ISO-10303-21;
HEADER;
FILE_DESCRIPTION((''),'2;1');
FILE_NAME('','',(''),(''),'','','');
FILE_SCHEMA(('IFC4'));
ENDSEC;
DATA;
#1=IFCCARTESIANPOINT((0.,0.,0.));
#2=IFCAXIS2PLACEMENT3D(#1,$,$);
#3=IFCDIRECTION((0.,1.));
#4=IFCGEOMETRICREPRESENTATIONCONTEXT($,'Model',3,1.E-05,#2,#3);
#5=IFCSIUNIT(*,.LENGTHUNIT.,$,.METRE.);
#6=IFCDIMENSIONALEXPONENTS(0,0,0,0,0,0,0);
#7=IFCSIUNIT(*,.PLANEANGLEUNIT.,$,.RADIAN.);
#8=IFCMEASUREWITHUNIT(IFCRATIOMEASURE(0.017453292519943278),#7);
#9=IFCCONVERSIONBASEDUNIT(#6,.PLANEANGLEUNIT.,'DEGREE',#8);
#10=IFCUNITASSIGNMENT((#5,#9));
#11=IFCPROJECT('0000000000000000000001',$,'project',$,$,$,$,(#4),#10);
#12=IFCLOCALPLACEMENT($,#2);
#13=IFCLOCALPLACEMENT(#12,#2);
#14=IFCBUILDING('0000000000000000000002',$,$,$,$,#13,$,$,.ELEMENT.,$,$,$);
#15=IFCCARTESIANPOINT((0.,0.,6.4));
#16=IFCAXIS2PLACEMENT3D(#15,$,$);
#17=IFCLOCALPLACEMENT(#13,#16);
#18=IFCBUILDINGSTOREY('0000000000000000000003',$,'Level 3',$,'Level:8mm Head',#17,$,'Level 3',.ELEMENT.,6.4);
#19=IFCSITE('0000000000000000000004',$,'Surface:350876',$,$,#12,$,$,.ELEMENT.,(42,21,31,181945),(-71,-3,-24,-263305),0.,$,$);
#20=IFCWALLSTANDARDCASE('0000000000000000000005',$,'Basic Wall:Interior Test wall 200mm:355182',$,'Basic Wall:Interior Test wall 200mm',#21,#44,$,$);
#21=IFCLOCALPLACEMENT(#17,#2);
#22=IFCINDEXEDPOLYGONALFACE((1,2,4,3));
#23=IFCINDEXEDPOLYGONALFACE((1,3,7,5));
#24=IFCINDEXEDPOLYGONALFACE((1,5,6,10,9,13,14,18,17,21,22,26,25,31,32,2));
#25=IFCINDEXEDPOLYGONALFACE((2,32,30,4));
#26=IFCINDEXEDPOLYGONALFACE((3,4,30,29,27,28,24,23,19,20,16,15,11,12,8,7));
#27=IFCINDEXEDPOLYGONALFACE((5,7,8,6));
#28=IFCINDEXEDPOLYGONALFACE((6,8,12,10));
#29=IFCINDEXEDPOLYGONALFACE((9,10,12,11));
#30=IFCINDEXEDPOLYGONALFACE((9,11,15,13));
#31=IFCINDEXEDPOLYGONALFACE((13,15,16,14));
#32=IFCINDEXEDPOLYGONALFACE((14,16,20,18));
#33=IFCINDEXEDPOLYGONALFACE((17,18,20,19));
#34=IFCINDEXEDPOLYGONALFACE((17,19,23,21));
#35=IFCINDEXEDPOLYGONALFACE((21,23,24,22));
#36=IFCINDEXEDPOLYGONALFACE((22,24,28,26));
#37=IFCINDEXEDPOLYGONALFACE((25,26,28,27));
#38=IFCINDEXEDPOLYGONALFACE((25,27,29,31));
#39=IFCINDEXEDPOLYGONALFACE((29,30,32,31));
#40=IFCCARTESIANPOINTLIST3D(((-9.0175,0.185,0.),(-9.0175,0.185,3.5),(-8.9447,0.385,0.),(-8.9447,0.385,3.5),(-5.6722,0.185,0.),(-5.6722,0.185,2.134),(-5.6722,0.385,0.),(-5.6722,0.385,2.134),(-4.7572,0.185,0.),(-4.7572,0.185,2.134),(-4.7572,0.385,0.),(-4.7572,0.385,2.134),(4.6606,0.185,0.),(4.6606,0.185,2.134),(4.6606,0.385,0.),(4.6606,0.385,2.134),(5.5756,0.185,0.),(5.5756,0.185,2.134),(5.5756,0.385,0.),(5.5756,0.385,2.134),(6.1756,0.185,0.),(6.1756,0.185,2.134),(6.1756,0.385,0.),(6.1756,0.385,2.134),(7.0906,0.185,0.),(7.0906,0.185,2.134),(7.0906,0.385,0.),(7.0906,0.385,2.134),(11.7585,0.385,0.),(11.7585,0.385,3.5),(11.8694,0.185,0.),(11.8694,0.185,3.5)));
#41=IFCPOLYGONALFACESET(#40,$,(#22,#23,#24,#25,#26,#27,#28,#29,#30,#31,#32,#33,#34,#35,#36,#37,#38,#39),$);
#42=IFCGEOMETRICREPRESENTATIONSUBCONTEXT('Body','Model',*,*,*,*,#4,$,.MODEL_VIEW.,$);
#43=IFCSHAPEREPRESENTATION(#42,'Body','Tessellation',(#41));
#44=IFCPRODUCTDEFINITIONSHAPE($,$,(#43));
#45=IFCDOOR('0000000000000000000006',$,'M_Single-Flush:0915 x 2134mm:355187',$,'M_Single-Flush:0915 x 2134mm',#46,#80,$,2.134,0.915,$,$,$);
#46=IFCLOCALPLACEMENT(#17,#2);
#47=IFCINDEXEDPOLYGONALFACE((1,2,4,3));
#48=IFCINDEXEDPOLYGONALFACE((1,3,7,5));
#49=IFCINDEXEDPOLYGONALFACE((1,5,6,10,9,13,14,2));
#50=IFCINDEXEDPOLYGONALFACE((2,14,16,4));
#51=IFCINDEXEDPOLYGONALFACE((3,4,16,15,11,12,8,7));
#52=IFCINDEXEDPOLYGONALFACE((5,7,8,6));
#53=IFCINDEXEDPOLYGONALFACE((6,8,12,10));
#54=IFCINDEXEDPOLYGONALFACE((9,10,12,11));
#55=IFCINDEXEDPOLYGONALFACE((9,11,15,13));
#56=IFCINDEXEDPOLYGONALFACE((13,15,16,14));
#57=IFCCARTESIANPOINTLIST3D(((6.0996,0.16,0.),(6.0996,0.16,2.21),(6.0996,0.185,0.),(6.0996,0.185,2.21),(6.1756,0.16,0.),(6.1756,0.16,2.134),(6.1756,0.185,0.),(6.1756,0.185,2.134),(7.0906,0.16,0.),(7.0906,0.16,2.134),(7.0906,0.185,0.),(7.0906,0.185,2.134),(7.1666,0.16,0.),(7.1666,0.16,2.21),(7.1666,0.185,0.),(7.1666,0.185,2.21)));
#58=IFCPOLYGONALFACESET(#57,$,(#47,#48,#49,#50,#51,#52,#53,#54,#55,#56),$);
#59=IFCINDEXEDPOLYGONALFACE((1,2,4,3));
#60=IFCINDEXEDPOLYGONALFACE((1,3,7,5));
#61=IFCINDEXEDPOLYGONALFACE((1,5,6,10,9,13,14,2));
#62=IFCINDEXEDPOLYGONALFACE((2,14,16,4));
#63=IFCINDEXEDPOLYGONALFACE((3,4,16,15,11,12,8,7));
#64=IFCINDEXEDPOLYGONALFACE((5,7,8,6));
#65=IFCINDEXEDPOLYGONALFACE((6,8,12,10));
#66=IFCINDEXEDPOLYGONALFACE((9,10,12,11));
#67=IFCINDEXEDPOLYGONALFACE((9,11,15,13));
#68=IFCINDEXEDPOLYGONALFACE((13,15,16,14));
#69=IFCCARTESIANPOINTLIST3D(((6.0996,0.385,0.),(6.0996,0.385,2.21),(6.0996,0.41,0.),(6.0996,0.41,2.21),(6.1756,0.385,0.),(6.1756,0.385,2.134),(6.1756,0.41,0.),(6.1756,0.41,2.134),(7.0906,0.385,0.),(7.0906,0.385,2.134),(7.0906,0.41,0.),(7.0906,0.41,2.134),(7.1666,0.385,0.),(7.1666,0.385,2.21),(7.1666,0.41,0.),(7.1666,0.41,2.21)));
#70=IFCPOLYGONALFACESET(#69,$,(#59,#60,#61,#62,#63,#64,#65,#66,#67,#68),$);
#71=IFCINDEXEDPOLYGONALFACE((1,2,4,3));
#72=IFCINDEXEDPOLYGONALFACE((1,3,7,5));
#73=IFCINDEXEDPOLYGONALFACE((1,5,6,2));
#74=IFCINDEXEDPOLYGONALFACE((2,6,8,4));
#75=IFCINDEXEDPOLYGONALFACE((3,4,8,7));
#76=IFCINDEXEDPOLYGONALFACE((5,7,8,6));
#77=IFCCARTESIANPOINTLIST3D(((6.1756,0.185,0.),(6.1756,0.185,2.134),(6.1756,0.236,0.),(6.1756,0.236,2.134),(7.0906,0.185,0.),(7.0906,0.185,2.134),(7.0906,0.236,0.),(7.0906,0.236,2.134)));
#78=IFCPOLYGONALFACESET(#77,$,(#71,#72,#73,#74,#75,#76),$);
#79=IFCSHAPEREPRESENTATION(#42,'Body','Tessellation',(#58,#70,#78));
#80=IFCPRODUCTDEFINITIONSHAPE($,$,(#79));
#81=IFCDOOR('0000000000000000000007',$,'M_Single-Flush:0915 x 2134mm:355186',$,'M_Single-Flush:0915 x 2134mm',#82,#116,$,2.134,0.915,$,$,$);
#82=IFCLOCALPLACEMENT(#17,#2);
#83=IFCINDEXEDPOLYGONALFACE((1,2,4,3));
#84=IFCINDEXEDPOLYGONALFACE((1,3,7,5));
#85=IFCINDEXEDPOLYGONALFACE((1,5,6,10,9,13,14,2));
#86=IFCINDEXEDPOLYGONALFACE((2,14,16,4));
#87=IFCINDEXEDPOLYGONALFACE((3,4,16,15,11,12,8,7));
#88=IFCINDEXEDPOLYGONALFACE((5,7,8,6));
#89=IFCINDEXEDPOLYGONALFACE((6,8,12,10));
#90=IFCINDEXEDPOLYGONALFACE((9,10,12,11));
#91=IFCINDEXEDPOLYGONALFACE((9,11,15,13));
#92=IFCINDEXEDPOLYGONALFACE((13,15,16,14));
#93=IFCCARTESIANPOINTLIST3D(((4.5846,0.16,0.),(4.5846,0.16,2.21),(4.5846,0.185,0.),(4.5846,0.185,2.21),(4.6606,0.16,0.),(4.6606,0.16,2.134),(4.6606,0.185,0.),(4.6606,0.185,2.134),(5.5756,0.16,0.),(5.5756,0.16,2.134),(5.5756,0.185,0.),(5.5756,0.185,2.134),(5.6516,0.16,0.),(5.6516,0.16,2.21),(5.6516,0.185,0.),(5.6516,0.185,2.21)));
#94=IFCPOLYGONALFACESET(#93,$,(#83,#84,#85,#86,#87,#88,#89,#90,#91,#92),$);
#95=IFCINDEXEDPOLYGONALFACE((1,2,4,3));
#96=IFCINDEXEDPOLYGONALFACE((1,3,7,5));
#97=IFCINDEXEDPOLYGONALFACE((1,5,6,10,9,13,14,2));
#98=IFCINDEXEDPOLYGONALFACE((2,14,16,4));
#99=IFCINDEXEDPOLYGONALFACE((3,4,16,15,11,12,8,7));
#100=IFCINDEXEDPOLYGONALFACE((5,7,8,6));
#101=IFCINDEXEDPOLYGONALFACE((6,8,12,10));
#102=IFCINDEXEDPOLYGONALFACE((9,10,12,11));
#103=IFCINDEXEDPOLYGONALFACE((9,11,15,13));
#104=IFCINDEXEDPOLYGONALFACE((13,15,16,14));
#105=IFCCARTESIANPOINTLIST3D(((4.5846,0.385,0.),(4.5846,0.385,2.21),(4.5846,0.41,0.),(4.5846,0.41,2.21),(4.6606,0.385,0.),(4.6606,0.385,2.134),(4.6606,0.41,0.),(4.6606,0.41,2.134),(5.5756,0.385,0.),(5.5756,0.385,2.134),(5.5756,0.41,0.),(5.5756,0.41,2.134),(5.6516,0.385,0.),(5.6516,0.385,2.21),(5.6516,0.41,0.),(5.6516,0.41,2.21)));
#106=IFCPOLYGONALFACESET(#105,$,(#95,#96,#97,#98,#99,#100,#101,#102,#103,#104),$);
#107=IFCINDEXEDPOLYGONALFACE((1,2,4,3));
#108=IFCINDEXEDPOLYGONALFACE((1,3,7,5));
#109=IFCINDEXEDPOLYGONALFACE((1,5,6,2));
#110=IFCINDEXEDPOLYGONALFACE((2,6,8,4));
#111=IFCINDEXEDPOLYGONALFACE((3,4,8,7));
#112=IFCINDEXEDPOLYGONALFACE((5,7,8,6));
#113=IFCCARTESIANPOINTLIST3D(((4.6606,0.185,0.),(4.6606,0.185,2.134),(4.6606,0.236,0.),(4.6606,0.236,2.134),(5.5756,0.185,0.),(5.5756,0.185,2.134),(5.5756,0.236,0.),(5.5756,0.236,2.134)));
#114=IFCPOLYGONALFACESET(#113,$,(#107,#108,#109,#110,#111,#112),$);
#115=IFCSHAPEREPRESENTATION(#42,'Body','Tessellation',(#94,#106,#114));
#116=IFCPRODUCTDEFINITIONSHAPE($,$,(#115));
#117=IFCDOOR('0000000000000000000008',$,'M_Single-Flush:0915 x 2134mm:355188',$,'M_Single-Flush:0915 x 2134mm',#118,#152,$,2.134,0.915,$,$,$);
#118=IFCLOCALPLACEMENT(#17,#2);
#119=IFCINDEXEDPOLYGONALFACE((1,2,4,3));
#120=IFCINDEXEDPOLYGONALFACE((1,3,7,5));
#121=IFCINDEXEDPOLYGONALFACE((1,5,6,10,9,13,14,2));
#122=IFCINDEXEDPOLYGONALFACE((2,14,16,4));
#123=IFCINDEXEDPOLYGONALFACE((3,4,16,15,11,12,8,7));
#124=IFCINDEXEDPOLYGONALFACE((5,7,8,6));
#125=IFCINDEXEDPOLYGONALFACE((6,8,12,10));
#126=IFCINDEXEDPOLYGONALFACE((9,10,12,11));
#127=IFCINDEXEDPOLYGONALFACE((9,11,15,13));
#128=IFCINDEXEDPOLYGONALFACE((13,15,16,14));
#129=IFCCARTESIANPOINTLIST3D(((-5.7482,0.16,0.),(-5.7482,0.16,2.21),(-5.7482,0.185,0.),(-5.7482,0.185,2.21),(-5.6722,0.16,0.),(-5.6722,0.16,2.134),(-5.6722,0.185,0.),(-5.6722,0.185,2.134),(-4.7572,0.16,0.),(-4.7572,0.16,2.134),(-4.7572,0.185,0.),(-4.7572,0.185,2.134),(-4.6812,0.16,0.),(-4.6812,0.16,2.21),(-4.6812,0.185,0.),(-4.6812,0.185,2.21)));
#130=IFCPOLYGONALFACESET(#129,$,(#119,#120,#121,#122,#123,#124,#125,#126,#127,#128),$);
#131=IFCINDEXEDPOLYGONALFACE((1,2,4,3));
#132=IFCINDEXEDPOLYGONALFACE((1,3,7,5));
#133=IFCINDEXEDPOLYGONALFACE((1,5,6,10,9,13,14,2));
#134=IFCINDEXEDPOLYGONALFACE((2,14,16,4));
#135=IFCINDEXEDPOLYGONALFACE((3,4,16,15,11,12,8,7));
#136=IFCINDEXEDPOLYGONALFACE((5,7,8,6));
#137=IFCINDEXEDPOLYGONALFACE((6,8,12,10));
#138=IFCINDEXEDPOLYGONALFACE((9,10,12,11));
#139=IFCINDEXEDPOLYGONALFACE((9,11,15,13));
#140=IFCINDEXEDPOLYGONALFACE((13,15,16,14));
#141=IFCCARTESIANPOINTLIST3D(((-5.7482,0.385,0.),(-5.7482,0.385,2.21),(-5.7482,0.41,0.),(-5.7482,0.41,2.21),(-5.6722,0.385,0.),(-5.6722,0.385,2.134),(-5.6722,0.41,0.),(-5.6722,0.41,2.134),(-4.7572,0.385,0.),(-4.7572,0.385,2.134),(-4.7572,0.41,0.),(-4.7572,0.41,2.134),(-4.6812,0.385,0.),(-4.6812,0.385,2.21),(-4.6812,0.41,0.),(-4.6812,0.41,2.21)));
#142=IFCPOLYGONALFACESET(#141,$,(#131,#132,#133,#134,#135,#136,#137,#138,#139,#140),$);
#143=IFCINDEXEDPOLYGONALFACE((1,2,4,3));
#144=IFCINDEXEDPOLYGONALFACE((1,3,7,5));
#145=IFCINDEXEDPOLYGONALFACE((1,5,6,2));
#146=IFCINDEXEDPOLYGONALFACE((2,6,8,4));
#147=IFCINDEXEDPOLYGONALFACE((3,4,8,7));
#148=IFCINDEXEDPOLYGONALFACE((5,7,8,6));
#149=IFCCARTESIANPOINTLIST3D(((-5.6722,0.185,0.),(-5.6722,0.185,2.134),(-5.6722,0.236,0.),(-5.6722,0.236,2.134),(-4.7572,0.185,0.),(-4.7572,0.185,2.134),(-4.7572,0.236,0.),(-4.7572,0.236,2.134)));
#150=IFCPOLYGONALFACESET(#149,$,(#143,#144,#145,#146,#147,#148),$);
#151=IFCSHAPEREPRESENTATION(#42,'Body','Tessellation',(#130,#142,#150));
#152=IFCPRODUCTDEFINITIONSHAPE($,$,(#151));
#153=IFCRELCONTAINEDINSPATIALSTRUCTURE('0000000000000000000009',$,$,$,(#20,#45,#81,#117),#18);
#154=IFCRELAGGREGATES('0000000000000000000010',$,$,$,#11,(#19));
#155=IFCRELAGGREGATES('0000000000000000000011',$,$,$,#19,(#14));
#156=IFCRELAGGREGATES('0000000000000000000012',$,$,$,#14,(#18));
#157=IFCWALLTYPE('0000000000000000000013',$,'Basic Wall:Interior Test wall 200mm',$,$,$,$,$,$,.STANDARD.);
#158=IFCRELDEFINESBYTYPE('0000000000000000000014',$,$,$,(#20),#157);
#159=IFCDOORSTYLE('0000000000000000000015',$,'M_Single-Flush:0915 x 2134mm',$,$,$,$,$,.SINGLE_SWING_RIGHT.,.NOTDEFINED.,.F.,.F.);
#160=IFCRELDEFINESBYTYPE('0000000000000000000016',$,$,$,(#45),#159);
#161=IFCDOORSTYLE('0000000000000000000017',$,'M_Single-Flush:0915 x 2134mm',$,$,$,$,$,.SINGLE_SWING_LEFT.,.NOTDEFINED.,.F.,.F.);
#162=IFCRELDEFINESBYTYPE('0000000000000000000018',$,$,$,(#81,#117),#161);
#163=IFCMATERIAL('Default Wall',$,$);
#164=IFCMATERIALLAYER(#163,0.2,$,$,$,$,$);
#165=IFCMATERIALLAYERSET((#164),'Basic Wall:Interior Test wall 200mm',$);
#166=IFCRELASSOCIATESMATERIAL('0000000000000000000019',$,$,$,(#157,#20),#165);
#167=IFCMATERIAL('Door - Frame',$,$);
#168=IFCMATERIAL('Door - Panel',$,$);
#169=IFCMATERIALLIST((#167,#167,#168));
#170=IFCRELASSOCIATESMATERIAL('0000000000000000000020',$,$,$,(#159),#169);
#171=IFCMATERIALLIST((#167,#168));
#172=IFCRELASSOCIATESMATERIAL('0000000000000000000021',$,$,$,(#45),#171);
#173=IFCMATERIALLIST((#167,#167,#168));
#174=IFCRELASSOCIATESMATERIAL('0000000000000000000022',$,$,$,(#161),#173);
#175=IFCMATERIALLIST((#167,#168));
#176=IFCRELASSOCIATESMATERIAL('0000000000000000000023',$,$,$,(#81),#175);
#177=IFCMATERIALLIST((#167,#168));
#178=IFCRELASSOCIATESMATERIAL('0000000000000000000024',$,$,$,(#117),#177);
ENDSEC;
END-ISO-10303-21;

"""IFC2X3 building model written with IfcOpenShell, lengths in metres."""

from ifc_helpers import new_model, entity, si_unit, converted_unit, direction, frame, frame_2d, origin, place, context, subcontext, project, spatial, polyline, rectangle, outline, extrude, source, transform, mapped, material, material_list, layer, layer_set, layer_usage, type_object, type_shapes, element, fill, save


model = new_model("IFC2X3")

# Units and contexts
model_context = context("Model", 3, precision=1e-05, world=origin(), true_north=direction((0.0, 1.0)))
body_context = subcontext(model_context, "Body", "Model", "MODEL_VIEW")
ifc_project = project(units=[si_unit("LENGTHUNIT", "METRE"), converted_unit("PLANEANGLEUNIT", "DEGREE", entity("IfcRatioMeasure", 0.017453292519943278), si_unit("PLANEANGLEUNIT", "RADIAN"), dimensions=[0, 0, 0, 0, 0, 0, 0])], contexts=[model_context])

# Site, building, storey
site_placement = place(None, origin())
site = spatial("IfcSite", under=ifc_project, at=site_placement, Name="Surface:350876", CompositionType="ELEMENT", RefLatitude=(42, 21, 31, 181945), RefLongitude=(-71, -3, -24, -263305), RefElevation=0.0)
building_placement = place(site_placement, origin())
building = spatial("IfcBuilding", under=site, at=building_placement, CompositionType="ELEMENT")
storey_placement = place(building_placement, frame((0.0, 0.0, 6.4)))
storey = spatial("IfcBuildingStorey", under=building, at=storey_placement, Name="Level 3", ObjectType="Level:8mm Head", LongName="Level 3", CompositionType="ELEMENT", Elevation=6.4)

# Shared definitions
ifc_material_1 = material(Name="Default Wall")

# Shared definitions
ifc_layer_1 = layer(ifc_material_1, 0.2)
ifc_layer_set_1 = layer_set([ifc_layer_1], Name="Basic Wall:Interior Test wall 200mm")
wall_type_1 = type_object("IfcWallType", Name="Basic Wall:Interior Test wall 200mm", PredefinedType="STANDARD", material=ifc_layer_set_1)

# Shared definitions
ifc_material_2 = material(Name="Door - Frame")
ifc_material_3 = material(Name="Door - Panel")
ifc_material_list_1 = material_list([ifc_material_2, ifc_material_2, ifc_material_3])
door_style_1 = type_object("IfcDoorStyle", Name="M_Single-Flush:0915 x 2134mm", ConstructionType="NOTDEFINED", OperationType="SINGLE_SWING_RIGHT", ParameterTakesPrecedence=False, Sizeable=False, material=ifc_material_list_1)
shared_shape_1 = source(origin(), body_context, "Body", "SweptSolid", [
    extrude(outline(polyline([(-0.5335, -1.124), (0.5335, -1.124), (0.5335, 1.086), (0.4575, 1.086), (0.4575, -1.048), (-0.4575, -1.048), (-0.4575, 1.086), (-0.5335, 1.086), (-0.5335, -1.124)])), frame((0.4575, 0.2, 1.086), z_axis=(0.0, 1.0, 0.0), x_axis=(1.0, 0.0, 0.0)), (0.0, 0.0, 1.0), 0.025),
    extrude(outline(polyline([(-1.124, -0.5335), (1.086, -0.5335), (1.086, -0.4575), (-1.048, -0.4575), (-1.048, 0.4575), (1.086, 0.4575), (1.086, 0.5335), (-1.124, 0.5335), (-1.124, -0.5335)])), frame((0.4575, -0.025, 1.086), z_axis=(0.0, 1.0, 0.0), x_axis=(0.0, 0.0, -1.0)), (0.0, 0.0, 1.0), 0.025),
    extrude(rectangle(XDim=0.051, YDim=0.915, at=frame_2d((0.0, 0.0), x_axis=(1.0, 0.0))), frame((0.4575, 0.1745, 0.0), z_axis=(0.0, 0.0, 1.0), x_axis=(0.0, 1.0, 0.0)), (0.0, 0.0, 1.0), 2.134),
])
type_shapes(door_style_1, [shared_shape_1])

# Wall, openings, doors
ifc_layer_usage_1 = layer_usage(ifc_layer_set_1, "AXIS2", "NEGATIVE", 0.1)
wall_1_placement = place(storey_placement, frame((-9.0175, 0.285, 0.0)))
wall_1 = element("IfcWallStandardCase", 1, at=wall_1_placement, inside=storey, type_object=wall_type_1, material=ifc_layer_usage_1, Name="Basic Wall:Interior Test wall 200mm:355182", ObjectType="Basic Wall:Interior Test wall 200mm", context=body_context, shape_type="SweptSolid", body=[
    extrude(outline(polyline([(0.0, -0.1), (20.6582, -0.1), (20.8869, -0.1), (20.7761, 0.1), (0.0728, 0.1), (0.0, -0.1)])), origin(), (0.0, 0.0, 1.0), 3.5),
])
opening_1_placement = place(wall_1_placement, frame((14.5931, 0.1, 0.0)))
opening_1 = element("IfcOpeningElement", 2, at=opening_1_placement, cuts=wall_1, ObjectType="Opening", context=body_context, shape_type="SweptSolid", body=[
    extrude(rectangle(XDim=0.915, YDim=2.134, at=frame_2d((1.067, 0.4575), x_axis=(0.0, -1.0))), frame((0.0, 0.0, 0.0), z_axis=(0.0, -1.0, 0.0), x_axis=(0.0, 0.0, 1.0)), (0.0, 0.0, 1.0), 0.2),
])
opening_2_placement = place(wall_1_placement, frame((16.1081, 0.1, 0.0)))
opening_2 = element("IfcOpeningElement", 3, at=opening_2_placement, cuts=wall_1, ObjectType="Opening", context=body_context, shape_type="SweptSolid", body=[
    extrude(rectangle(XDim=0.915, YDim=2.134, at=frame_2d((1.067, 0.4575), x_axis=(0.0, 1.0))), frame((0.0, 0.0, 0.0), z_axis=(0.0, -1.0, 0.0), x_axis=(0.0, 0.0, 1.0)), (0.0, 0.0, 1.0), 0.2),
])
opening_3_placement = place(wall_1_placement, frame((4.2603, 0.1, 0.0)))
opening_3 = element("IfcOpeningElement", 4, at=opening_3_placement, cuts=wall_1, ObjectType="Opening", context=body_context, shape_type="SweptSolid", body=[
    extrude(rectangle(XDim=0.915, YDim=2.134, at=frame_2d((1.067, 0.4575), x_axis=(0.0, -1.0))), frame((0.0, 0.0, 0.0), z_axis=(0.0, -1.0, 0.0), x_axis=(0.0, 0.0, 1.0)), (0.0, 0.0, 1.0), 0.2),
])
ifc_material_list_2 = material_list([ifc_material_2, ifc_material_3])
door_1_placement = place(opening_2_placement, frame((0.0, 0.0, 0.0), z_axis=(0.0, 0.0, 1.0), x_axis=(-1.0, 0.0, 0.0)))
door_1 = element("IfcDoor", 5, at=door_1_placement, inside=storey, type_object=door_style_1, material=ifc_material_list_2, Name="M_Single-Flush:0915 x 2134mm:355187", ObjectType="M_Single-Flush:0915 x 2134mm", OverallHeight=2.134, OverallWidth=0.915, context=body_context, shape_type="MappedRepresentation", body=[
    mapped(shared_shape_1, transform((0.0, 0.0, 0.0), scale=1.0)),
])
fill(opening_2, door_1)
ifc_material_list_3 = material_list([ifc_material_2, ifc_material_3])
ifc_material_list_4 = material_list([ifc_material_2, ifc_material_2, ifc_material_3])
door_style_2 = type_object("IfcDoorStyle", Name="M_Single-Flush:0915 x 2134mm", ConstructionType="NOTDEFINED", OperationType="SINGLE_SWING_LEFT", ParameterTakesPrecedence=False, Sizeable=False, material=ifc_material_list_4)
shared_shape_2 = source(origin(), body_context, "Body", "SweptSolid", [
    extrude(outline(polyline([(-0.5335, -1.124), (0.5335, -1.124), (0.5335, 1.086), (0.4575, 1.086), (0.4575, -1.048), (-0.4575, -1.048), (-0.4575, 1.086), (-0.5335, 1.086), (-0.5335, -1.124)])), frame((0.4575, 0.225, 1.086), z_axis=(0.0, -1.0, 0.0), x_axis=(-1.0, 0.0, 0.0)), (0.0, 0.0, 1.0), 0.025),
    extrude(outline(polyline([(-1.124, -0.5335), (1.086, -0.5335), (1.086, -0.4575), (-1.048, -0.4575), (-1.048, 0.4575), (1.086, 0.4575), (1.086, 0.5335), (-1.124, 0.5335), (-1.124, -0.5335)])), frame((0.4575, 0.0, 1.086), z_axis=(0.0, -1.0, 0.0), x_axis=(0.0, 0.0, -1.0)), (0.0, 0.0, 1.0), 0.025),
    extrude(rectangle(XDim=0.915, YDim=0.051, at=frame_2d((0.0, 0.0), x_axis=(1.0, 0.0))), frame((0.4575, 0.1745, 0.0)), (0.0, 0.0, 1.0), 2.134),
])
type_shapes(door_style_2, [shared_shape_2])
door_2_placement = place(opening_1_placement, frame((0.0, 0.0, 0.0), z_axis=(0.0, 0.0, 1.0), x_axis=(-1.0, 0.0, 0.0)))
door_2 = element("IfcDoor", 6, at=door_2_placement, inside=storey, type_object=door_style_2, material=ifc_material_list_3, Name="M_Single-Flush:0915 x 2134mm:355186", ObjectType="M_Single-Flush:0915 x 2134mm", OverallHeight=2.134, OverallWidth=0.915, context=body_context, shape_type="MappedRepresentation", body=[
    mapped(shared_shape_2, transform((0.0, 0.0, 0.0), scale=1.0)),
])
fill(opening_1, door_2)
ifc_material_list_5 = material_list([ifc_material_2, ifc_material_3])
door_3_placement = place(opening_3_placement, frame((0.0, 0.0, 0.0), z_axis=(0.0, 0.0, 1.0), x_axis=(-1.0, 0.0, 0.0)))
door_3 = element("IfcDoor", 7, at=door_3_placement, inside=storey, type_object=door_style_2, material=ifc_material_list_5, Name="M_Single-Flush:0915 x 2134mm:355188", ObjectType="M_Single-Flush:0915 x 2134mm", OverallHeight=2.134, OverallWidth=0.915, context=body_context, shape_type="MappedRepresentation", body=[
    mapped(shared_shape_2, transform((0.0, 0.0, 0.0), scale=1.0)),
])
fill(opening_3, door_3)

save(model, "model.ifc")
